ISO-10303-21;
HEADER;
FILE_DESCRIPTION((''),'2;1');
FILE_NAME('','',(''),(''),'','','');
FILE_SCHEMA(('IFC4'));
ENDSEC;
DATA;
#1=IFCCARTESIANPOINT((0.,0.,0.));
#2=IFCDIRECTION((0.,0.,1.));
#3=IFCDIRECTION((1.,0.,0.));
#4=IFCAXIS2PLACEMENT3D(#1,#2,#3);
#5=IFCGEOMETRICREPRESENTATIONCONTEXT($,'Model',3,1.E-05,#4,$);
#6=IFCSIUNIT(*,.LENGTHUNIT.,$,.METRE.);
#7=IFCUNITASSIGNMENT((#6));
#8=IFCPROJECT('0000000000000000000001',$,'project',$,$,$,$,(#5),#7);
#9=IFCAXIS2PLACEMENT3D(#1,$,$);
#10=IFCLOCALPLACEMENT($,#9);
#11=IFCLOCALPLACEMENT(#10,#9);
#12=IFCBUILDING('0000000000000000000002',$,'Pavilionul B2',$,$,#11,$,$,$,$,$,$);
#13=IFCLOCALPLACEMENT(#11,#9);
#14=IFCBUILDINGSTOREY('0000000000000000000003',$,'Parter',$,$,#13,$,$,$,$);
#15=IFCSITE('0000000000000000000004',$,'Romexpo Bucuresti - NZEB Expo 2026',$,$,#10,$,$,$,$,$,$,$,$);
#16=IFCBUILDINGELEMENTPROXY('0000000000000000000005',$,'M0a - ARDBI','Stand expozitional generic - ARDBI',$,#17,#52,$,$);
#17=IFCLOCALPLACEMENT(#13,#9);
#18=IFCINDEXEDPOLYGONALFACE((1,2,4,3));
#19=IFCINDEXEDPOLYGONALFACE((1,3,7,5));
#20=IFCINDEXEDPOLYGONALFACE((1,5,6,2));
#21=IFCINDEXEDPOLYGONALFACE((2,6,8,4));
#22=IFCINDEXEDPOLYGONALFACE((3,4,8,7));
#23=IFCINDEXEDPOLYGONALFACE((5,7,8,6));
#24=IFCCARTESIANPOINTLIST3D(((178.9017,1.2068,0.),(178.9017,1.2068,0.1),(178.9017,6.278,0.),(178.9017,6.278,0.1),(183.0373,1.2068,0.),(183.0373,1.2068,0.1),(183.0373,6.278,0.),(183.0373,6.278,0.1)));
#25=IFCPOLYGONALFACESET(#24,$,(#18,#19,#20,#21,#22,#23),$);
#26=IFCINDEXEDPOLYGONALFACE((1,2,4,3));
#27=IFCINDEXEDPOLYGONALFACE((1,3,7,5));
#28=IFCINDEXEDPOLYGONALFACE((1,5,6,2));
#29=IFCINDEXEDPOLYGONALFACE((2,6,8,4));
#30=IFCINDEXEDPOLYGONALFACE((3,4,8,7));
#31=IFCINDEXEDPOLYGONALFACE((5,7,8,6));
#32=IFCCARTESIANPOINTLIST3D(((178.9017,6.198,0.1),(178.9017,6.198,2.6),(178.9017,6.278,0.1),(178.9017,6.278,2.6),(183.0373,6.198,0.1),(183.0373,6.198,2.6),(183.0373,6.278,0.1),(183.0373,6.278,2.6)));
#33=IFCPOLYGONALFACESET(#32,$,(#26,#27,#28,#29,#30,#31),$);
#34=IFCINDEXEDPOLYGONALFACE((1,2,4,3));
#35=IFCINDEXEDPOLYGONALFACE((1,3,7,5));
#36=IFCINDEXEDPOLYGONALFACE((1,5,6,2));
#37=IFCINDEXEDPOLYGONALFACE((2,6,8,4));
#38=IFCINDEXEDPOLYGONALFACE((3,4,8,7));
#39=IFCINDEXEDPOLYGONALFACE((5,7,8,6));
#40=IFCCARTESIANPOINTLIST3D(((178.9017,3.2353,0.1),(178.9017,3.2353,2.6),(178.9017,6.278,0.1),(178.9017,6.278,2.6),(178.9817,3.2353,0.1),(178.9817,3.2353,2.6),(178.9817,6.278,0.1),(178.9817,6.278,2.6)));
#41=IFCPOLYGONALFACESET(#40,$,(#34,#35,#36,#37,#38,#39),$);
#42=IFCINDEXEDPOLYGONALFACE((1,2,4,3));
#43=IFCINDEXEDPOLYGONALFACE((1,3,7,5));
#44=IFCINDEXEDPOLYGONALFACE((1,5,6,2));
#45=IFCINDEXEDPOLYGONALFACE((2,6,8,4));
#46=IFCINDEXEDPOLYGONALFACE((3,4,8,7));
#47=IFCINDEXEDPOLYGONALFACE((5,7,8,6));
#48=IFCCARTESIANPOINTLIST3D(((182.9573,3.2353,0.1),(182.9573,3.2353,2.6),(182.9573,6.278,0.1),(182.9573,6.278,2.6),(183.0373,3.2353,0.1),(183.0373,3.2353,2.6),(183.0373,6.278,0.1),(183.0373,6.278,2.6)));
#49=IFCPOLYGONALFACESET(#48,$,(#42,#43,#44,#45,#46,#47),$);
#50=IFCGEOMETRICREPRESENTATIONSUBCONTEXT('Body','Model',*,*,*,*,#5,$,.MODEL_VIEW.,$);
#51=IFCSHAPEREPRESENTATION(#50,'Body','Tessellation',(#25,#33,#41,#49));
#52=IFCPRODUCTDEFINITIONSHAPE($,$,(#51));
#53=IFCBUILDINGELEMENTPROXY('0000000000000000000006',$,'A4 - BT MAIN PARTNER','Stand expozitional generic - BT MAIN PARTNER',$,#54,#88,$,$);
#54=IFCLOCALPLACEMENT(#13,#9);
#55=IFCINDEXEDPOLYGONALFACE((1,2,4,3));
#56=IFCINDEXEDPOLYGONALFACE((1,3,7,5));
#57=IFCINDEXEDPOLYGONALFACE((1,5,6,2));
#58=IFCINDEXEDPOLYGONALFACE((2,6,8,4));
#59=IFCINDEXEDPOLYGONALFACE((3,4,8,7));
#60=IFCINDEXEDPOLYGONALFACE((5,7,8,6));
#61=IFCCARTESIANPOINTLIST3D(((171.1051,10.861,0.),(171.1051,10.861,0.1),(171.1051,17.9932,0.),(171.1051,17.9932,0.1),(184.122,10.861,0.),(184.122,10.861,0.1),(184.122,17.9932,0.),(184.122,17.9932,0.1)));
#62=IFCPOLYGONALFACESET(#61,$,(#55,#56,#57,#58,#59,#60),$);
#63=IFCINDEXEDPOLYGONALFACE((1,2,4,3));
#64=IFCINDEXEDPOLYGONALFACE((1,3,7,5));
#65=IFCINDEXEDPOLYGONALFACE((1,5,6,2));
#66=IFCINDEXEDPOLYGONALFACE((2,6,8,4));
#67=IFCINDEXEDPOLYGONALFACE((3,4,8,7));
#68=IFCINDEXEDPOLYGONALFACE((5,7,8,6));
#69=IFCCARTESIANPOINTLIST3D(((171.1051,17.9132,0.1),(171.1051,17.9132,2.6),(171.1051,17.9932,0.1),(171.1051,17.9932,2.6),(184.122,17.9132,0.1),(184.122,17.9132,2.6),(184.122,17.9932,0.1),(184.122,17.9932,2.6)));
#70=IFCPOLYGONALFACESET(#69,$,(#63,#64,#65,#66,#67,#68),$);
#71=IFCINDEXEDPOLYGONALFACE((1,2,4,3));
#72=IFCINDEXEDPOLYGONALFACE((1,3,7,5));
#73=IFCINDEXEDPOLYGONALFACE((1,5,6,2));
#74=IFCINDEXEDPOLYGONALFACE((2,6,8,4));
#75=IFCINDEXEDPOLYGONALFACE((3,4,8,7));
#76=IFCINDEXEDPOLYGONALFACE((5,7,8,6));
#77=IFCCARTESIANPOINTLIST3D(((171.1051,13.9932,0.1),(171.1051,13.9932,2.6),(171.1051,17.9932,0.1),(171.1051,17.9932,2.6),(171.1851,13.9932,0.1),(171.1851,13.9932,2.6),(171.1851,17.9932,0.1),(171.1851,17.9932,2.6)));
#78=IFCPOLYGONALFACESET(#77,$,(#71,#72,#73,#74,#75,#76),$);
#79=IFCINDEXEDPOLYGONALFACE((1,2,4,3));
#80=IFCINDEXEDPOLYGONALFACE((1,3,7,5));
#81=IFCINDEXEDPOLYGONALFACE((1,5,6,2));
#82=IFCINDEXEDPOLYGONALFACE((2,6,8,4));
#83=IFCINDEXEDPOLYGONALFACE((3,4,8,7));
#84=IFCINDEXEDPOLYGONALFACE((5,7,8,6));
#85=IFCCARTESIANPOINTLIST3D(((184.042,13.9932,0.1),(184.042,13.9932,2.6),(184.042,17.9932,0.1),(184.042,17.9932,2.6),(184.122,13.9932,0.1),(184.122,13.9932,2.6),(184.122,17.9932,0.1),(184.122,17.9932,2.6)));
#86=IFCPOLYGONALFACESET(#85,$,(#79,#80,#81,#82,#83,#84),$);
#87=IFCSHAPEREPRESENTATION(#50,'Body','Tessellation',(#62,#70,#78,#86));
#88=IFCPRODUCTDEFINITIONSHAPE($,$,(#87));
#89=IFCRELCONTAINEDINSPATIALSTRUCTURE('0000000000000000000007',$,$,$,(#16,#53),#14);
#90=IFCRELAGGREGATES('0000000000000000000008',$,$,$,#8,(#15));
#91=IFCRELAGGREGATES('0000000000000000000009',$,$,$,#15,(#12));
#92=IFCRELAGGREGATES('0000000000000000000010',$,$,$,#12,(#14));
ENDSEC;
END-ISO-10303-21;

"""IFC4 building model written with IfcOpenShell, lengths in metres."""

from ifc_helpers import new_model, si_unit, frame, frame_2d, origin, origin_with_axes, place, context, subcontext, project, spatial, rectangle, extrude, element, save


model = new_model("IFC4")

# Units and contexts
model_context = context("Model", 3, precision=1e-05, world=origin_with_axes())
body_context = subcontext(model_context, "Body", "Model", "MODEL_VIEW")
ifc_project = project(units=[si_unit("LENGTHUNIT", "METRE")], contexts=[model_context])

# Site, building, storey
site_placement = place(None, origin())
site = spatial("IfcSite", under=ifc_project, at=site_placement, Name="Romexpo Bucuresti - NZEB Expo 2026")
building_placement = place(site_placement, origin())
building = spatial("IfcBuilding", under=site, at=building_placement, Name="Pavilionul B2")
storey_placement = place(building_placement, origin())
storey = spatial("IfcBuildingStorey", under=building, at=storey_placement, Name="Parter")

# Building element proxies
proxy_1_placement = place(storey_placement, frame((178.9017, 1.2068, 0.0), z_axis=(0.0, 0.0, 1.0), x_axis=(1.0, 0.0, 0.0)))
element("IfcBuildingElementProxy", 1, at=proxy_1_placement, inside=storey, Name="M0a - ARDBI", Description="Stand expozitional generic - ARDBI", context=body_context, shape_type="SweptSolid", body=[
    extrude(rectangle(XDim=4.1356, YDim=5.0712, at=frame_2d((2.0678, 2.5356))), origin(), (0.0, 0.0, 1.0), 0.1),
    extrude(rectangle(XDim=4.1356, YDim=0.08, at=frame_2d((2.0678, 5.0312))), frame((0.0, 0.0, 0.1)), (0.0, 0.0, 1.0), 2.5),
    extrude(rectangle(XDim=0.08, YDim=3.0427, at=frame_2d((0.04, 3.5498))), frame((0.0, 0.0, 0.1)), (0.0, 0.0, 1.0), 2.5),
    extrude(rectangle(XDim=0.08, YDim=3.0427, at=frame_2d((4.0956, 3.5498))), frame((0.0, 0.0, 0.1)), (0.0, 0.0, 1.0), 2.5),
])
proxy_2_placement = place(storey_placement, frame((171.1051, 10.861, 0.0), z_axis=(0.0, 0.0, 1.0), x_axis=(1.0, 0.0, 0.0)))
element("IfcBuildingElementProxy", 2, at=proxy_2_placement, inside=storey, Name="A4 - BT MAIN PARTNER", Description="Stand expozitional generic - BT MAIN PARTNER", context=body_context, shape_type="SweptSolid", body=[
    extrude(rectangle(XDim=13.0169, YDim=7.1322, at=frame_2d((6.5085, 3.5661))), origin(), (0.0, 0.0, 1.0), 0.1),
    extrude(rectangle(XDim=13.0169, YDim=0.08, at=frame_2d((6.5085, 7.0922))), frame((0.0, 0.0, 0.1)), (0.0, 0.0, 1.0), 2.5),
    extrude(rectangle(XDim=0.08, YDim=4.0, at=frame_2d((0.04, 5.1322))), frame((0.0, 0.0, 0.1)), (0.0, 0.0, 1.0), 2.5),
    extrude(rectangle(XDim=0.08, YDim=4.0, at=frame_2d((12.9769, 5.1322))), frame((0.0, 0.0, 0.1)), (0.0, 0.0, 1.0), 2.5),
])

save(model, "model.ifc")
